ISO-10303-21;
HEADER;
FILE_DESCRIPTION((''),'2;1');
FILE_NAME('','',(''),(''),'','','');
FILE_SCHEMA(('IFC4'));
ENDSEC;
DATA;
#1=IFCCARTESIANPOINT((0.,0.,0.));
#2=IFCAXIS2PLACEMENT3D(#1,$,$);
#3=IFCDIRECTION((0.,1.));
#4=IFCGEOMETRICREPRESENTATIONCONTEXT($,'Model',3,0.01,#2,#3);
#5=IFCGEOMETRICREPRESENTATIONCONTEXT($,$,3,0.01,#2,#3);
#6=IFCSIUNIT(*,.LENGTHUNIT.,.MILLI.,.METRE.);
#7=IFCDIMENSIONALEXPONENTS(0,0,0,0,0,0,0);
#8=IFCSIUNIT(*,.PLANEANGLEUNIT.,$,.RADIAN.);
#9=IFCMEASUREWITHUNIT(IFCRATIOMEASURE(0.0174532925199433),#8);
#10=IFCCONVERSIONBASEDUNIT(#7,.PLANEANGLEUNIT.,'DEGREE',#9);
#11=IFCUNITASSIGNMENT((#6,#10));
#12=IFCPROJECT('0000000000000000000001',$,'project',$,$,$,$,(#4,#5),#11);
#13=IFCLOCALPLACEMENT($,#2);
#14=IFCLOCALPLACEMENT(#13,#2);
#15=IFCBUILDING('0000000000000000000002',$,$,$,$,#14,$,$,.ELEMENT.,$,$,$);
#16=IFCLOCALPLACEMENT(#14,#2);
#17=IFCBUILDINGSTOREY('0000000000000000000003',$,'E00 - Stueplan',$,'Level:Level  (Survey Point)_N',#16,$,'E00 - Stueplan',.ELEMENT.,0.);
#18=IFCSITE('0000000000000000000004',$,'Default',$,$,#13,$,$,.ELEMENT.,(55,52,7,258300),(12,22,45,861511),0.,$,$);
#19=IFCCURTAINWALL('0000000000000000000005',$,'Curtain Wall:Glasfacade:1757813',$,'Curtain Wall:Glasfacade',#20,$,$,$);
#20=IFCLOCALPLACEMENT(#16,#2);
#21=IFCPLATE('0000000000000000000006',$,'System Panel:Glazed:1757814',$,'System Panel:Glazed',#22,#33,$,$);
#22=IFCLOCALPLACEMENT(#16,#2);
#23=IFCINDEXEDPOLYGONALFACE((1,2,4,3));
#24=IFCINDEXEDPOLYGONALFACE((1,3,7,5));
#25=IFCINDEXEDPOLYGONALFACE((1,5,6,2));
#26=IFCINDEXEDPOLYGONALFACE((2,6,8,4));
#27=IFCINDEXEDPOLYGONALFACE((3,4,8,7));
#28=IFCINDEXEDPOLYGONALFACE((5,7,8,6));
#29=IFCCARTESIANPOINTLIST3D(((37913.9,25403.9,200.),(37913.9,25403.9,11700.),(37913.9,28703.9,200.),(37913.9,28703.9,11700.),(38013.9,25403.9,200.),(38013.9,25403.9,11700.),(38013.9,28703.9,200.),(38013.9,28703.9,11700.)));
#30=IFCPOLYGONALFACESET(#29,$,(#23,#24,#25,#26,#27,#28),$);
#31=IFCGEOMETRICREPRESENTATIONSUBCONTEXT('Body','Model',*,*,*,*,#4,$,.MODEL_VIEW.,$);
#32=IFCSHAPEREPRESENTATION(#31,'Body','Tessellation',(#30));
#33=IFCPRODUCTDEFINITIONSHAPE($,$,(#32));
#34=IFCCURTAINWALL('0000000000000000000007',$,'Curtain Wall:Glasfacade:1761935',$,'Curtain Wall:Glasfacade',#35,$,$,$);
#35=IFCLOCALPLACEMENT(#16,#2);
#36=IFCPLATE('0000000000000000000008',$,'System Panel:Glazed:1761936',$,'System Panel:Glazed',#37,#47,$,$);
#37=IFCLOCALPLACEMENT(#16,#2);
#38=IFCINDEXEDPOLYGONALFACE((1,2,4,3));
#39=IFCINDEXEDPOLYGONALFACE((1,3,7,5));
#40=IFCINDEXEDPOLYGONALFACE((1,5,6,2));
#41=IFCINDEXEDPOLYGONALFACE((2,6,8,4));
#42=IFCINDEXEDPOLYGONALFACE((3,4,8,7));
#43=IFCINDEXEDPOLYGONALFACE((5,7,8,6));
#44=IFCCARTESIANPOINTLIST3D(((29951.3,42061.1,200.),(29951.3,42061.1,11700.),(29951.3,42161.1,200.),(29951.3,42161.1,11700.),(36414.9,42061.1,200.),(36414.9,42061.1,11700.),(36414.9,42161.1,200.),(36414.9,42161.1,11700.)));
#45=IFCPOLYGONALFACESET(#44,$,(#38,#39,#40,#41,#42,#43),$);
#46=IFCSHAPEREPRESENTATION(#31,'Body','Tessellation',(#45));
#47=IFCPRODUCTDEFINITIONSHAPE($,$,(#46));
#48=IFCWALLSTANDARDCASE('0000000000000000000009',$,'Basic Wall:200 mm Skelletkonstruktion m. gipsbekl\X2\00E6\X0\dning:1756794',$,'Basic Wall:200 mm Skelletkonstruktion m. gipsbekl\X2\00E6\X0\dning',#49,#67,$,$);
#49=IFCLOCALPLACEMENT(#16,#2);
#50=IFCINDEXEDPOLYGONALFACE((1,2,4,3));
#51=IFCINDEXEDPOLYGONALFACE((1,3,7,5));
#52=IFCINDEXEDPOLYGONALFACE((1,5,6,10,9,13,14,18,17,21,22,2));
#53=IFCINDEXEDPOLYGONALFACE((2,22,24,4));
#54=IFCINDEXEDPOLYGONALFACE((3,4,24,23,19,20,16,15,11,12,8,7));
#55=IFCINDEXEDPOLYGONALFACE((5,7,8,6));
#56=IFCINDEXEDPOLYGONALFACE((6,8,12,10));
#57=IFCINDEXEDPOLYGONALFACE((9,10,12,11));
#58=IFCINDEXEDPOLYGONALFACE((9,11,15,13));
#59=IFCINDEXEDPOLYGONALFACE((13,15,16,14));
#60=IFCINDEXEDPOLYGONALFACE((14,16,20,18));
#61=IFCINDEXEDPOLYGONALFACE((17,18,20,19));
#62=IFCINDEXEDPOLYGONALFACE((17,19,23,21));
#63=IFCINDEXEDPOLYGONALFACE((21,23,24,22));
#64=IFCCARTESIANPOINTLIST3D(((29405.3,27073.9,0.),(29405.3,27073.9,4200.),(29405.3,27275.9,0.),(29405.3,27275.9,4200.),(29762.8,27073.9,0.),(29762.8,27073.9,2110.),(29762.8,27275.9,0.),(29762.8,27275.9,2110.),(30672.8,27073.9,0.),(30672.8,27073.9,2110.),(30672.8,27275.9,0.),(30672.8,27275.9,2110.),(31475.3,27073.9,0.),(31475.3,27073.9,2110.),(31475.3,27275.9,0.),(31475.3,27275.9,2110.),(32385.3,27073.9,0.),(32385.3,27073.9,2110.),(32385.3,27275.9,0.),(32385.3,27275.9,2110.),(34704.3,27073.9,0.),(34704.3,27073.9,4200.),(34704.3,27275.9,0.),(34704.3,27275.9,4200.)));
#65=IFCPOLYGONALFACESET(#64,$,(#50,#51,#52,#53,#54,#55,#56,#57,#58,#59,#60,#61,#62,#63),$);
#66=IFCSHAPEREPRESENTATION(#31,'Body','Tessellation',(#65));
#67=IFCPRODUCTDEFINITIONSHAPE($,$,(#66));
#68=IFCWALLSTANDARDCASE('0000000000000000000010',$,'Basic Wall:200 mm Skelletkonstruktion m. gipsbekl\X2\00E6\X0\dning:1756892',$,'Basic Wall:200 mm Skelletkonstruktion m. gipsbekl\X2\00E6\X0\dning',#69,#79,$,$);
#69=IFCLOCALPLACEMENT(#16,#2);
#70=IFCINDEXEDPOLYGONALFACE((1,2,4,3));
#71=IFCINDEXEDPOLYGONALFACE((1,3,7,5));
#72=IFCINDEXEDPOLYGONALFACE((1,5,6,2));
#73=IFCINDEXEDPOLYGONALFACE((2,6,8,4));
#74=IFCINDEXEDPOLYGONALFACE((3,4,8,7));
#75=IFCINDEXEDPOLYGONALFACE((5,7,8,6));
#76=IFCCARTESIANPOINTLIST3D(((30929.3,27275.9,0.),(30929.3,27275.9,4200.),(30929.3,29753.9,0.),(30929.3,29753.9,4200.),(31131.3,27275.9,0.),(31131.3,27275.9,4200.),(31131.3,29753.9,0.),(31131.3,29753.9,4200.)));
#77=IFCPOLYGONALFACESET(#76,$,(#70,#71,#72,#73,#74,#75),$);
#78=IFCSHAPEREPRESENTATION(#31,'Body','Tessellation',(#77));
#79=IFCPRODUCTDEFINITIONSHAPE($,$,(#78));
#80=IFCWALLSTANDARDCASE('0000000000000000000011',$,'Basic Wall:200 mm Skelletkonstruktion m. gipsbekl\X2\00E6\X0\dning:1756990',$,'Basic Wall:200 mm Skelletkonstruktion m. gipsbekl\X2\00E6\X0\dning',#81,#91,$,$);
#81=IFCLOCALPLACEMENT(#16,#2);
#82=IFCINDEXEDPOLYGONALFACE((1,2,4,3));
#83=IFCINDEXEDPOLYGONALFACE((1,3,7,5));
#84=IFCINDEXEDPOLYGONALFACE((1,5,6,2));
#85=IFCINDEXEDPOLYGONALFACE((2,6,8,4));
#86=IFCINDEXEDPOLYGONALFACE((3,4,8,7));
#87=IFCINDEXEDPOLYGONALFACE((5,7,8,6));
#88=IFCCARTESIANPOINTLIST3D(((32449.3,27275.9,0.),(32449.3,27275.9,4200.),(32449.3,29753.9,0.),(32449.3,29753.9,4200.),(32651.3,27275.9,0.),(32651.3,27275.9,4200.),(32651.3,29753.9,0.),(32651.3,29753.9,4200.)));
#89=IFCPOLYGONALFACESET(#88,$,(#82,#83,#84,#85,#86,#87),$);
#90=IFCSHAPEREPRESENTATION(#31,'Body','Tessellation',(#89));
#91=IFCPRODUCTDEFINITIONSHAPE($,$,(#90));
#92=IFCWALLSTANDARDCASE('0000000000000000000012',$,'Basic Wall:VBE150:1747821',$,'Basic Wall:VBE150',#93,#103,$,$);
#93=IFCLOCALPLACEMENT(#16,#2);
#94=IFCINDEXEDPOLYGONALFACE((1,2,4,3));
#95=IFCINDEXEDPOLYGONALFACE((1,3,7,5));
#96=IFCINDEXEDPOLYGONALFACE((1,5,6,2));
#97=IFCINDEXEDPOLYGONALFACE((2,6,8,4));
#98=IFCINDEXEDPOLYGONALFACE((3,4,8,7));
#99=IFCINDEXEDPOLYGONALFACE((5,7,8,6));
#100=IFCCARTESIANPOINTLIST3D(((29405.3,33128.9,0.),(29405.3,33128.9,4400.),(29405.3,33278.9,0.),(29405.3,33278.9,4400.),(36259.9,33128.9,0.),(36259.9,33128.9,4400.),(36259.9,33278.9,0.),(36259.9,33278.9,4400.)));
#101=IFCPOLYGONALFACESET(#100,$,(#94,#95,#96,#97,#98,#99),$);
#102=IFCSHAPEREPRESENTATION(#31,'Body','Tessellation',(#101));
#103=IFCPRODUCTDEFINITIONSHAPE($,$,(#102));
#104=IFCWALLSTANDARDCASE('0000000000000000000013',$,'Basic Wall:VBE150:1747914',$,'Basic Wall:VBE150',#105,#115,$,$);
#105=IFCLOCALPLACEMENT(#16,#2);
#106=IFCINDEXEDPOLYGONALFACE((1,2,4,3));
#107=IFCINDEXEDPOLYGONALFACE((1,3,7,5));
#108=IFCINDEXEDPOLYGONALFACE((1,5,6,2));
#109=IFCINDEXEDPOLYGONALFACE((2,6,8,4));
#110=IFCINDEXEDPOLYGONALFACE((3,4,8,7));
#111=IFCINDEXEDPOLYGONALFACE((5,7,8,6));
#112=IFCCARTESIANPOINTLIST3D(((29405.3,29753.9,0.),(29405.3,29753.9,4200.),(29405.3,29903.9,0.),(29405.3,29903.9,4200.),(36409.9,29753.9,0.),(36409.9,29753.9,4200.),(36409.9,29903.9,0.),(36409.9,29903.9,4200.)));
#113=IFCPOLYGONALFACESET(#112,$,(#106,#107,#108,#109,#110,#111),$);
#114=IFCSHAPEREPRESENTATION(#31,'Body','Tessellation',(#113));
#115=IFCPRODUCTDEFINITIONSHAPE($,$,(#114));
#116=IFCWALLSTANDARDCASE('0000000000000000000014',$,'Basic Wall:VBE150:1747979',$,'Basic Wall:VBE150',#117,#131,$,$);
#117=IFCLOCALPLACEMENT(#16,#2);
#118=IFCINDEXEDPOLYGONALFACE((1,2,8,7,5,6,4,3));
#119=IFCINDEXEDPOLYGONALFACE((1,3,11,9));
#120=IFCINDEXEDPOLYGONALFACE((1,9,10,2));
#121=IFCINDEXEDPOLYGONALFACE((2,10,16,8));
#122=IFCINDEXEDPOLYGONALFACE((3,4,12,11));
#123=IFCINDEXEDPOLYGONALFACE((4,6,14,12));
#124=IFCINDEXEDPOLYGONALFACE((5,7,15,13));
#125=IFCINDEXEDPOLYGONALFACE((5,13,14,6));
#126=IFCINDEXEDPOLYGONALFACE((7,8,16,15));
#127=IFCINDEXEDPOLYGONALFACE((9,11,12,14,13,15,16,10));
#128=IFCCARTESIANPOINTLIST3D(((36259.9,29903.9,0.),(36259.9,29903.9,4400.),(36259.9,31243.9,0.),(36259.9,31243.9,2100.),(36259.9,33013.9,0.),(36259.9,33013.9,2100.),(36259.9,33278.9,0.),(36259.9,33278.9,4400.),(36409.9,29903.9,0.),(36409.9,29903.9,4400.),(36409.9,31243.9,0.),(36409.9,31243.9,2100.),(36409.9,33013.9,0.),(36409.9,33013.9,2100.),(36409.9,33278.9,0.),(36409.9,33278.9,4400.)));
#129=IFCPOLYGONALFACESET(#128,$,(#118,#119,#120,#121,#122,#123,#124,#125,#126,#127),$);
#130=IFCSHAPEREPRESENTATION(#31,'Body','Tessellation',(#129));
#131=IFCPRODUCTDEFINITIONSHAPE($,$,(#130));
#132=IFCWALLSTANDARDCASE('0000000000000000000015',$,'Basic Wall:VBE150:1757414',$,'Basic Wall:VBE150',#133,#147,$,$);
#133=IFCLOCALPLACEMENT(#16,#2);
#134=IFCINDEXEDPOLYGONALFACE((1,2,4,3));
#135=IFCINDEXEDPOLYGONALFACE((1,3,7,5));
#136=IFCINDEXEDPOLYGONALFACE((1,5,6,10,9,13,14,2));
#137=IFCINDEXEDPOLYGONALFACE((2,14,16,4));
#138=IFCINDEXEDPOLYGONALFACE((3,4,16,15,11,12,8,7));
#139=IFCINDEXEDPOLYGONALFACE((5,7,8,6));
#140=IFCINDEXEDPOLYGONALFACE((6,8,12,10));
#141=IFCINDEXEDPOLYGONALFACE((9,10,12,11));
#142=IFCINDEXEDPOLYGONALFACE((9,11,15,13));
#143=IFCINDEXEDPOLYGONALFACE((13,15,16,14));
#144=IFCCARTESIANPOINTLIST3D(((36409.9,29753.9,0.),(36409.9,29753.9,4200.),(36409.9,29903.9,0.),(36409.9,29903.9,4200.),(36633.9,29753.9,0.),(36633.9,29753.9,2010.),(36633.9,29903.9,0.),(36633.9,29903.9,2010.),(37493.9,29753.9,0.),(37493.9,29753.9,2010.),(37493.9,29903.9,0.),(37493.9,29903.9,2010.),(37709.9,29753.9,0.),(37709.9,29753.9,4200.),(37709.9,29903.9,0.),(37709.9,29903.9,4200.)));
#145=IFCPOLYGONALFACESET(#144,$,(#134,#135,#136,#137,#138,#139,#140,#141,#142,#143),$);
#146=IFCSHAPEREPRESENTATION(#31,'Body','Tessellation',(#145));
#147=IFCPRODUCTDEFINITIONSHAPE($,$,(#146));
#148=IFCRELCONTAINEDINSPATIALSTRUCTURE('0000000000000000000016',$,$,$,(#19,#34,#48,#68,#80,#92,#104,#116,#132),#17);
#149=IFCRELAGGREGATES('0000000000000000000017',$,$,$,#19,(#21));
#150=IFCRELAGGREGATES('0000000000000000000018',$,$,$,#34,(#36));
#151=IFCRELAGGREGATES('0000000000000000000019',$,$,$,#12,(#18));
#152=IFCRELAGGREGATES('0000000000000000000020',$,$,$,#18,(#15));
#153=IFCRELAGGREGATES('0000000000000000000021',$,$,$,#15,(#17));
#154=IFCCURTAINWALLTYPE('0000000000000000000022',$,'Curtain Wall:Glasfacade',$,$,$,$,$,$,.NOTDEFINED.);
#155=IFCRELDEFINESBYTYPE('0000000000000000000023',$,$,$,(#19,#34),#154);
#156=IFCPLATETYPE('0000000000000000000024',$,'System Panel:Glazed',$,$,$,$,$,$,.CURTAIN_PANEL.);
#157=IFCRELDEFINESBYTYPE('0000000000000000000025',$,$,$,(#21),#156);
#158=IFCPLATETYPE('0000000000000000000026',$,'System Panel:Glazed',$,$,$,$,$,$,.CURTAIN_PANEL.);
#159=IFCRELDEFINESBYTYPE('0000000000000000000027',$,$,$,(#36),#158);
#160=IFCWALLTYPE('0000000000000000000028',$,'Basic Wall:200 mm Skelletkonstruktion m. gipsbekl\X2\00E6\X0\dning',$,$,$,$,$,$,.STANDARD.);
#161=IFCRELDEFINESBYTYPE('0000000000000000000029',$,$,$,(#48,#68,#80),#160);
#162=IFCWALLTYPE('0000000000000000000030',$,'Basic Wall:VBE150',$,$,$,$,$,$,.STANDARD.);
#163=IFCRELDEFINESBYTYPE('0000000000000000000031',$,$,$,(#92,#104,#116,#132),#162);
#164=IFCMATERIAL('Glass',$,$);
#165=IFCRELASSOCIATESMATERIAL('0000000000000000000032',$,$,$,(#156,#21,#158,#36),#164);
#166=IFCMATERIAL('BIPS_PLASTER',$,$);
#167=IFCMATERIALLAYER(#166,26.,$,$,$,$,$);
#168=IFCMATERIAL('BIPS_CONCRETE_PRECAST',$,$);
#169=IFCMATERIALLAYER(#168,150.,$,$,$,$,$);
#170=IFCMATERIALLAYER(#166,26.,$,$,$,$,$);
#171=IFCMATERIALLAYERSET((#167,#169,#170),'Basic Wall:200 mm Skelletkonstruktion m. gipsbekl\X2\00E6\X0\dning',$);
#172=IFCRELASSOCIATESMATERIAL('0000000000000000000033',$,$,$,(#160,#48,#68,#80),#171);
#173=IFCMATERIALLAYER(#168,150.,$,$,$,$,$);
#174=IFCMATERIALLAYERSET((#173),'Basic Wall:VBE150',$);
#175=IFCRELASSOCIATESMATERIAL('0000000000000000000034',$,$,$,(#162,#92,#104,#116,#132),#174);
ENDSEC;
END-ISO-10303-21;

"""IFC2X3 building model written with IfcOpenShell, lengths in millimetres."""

from ifc_helpers import new_model, entity, si_unit, converted_unit, direction, frame, frame_2d, origin, origin_2d_with_axis, place, context, subcontext, project, spatial, rectangle, extrude, source, transform, mapped, material, layer, layer_set, layer_usage, type_object, type_shapes, element, aggregate, save


model = new_model("IFC2X3")

# Units and contexts
model_context = context("Model", 3, precision=0.01, world=origin(), true_north=direction((0.0, 1.0)))
context_of_model = context(None, 3, precision=0.01, world=origin(), true_north=direction((0.0, 1.0)))
body_context = subcontext(model_context, "Body", "Model", "MODEL_VIEW")
ifc_project = project(units=[si_unit("LENGTHUNIT", "METRE", prefix="MILLI"), converted_unit("PLANEANGLEUNIT", "DEGREE", entity("IfcRatioMeasure", 0.0174532925199433), si_unit("PLANEANGLEUNIT", "RADIAN"), dimensions=[0, 0, 0, 0, 0, 0, 0])], contexts=[model_context, context_of_model])

# Site, building, storey
site_placement = place(None, origin())
site = spatial("IfcSite", under=ifc_project, at=site_placement, Name="Default", CompositionType="ELEMENT", RefLatitude=(55, 52, 7, 258300), RefLongitude=(12, 22, 45, 861511), RefElevation=0.0)
building_placement = place(site_placement, origin())
building = spatial("IfcBuilding", under=site, at=building_placement, CompositionType="ELEMENT")
storey_placement = place(building_placement, origin())
storey = spatial("IfcBuildingStorey", under=building, at=storey_placement, Name="E00 - Stueplan", ObjectType="Level:Level  (Survey Point)_N", LongName="E00 - Stueplan", CompositionType="ELEMENT", Elevation=0.0)

# Curtain walls, plates
curtain_wall_type = type_object("IfcCurtainWallType", Name="Curtain Wall:Glasfacade", PredefinedType="NOTDEFINED")
curtain_wall_1_placement = place(storey_placement, origin())
curtain_wall_1 = element("IfcCurtainWall", 1, at=curtain_wall_1_placement, inside=storey, type_object=curtain_wall_type, Name="Curtain Wall:Glasfacade:1757813", ObjectType="Curtain Wall:Glasfacade")
ifc_material_1 = material(Name="Glass")
plate_type_1 = type_object("IfcPlateType", Name="System Panel:Glazed", PredefinedType="CURTAIN_PANEL", material=ifc_material_1)
shared_shape_1 = source(origin(), body_context, "Body", "SweptSolid", [
    extrude(rectangle(XDim=100.0, YDim=3300.0, at=origin_2d_with_axis()), frame((0.0, 0.0, 0.0), z_axis=(0.0, 0.0, 1.0), x_axis=(0.0, 1.0, 0.0)), (0.0, 0.0, 1.0), 11500.0),
])
type_shapes(plate_type_1, [shared_shape_1])
plate_1_placement = place(curtain_wall_1_placement, frame((37963.9, 27053.9, 200.0), z_axis=(0.0, 0.0, 1.0), x_axis=(0.0, -1.0, 0.0)))
plate_1 = element("IfcPlate", 2, at=plate_1_placement, type_object=plate_type_1, material=ifc_material_1, Name="System Panel:Glazed:1757814", ObjectType="System Panel:Glazed", context=body_context, shape_type="MappedRepresentation", body=[
    mapped(shared_shape_1, transform((0.0, 0.0, 0.0), scale=1.0)),
])
aggregate(curtain_wall_1, [plate_1])
curtain_wall_2_placement = place(storey_placement, origin())
curtain_wall_2 = element("IfcCurtainWall", 3, at=curtain_wall_2_placement, inside=storey, type_object=curtain_wall_type, Name="Curtain Wall:Glasfacade:1761935", ObjectType="Curtain Wall:Glasfacade")
plate_type_2 = type_object("IfcPlateType", Name="System Panel:Glazed", PredefinedType="CURTAIN_PANEL", material=ifc_material_1)
shared_shape_2 = source(origin(), body_context, "Body", "SweptSolid", [
    extrude(rectangle(XDim=100.0, YDim=6463.6, at=origin_2d_with_axis()), frame((0.0, 0.0, 0.0), z_axis=(0.0, 0.0, 1.0), x_axis=(0.0, 1.0, 0.0)), (0.0, 0.0, 1.0), 11500.0),
])
type_shapes(plate_type_2, [shared_shape_2])
plate_2_placement = place(curtain_wall_2_placement, frame((33183.1, 42111.1, 200.0)))
plate_2 = element("IfcPlate", 4, at=plate_2_placement, type_object=plate_type_2, material=ifc_material_1, Name="System Panel:Glazed:1761936", ObjectType="System Panel:Glazed", context=body_context, shape_type="MappedRepresentation", body=[
    mapped(shared_shape_2, transform((0.0, 0.0, 0.0), scale=1.0)),
])
aggregate(curtain_wall_2, [plate_2])

# Wall, openings
ifc_material_2 = material(Name="BIPS_CONCRETE_PRECAST")
ifc_material_3 = material(Name="BIPS_PLASTER")
ifc_layer_1 = layer(ifc_material_3, 26.0)
ifc_layer_2 = layer(ifc_material_2, 150.0)
ifc_layer_3 = layer(ifc_material_3, 26.0)
ifc_layer_set_1 = layer_set([ifc_layer_1, ifc_layer_2, ifc_layer_3], Name="Basic Wall:200 mm Skelletkonstruktion m. gipsbeklædning")
ifc_layer_usage_1 = layer_usage(ifc_layer_set_1, "AXIS2", "NEGATIVE", 101.0)
wall_type_1 = type_object("IfcWallType", Name="Basic Wall:200 mm Skelletkonstruktion m. gipsbeklædning", PredefinedType="STANDARD", material=ifc_layer_set_1)
wall_1_placement = place(storey_placement, frame((29405.3, 27174.9, 0.0)))
wall_1 = element("IfcWallStandardCase", 5, at=wall_1_placement, inside=storey, type_object=wall_type_1, material=ifc_layer_usage_1, Name="Basic Wall:200 mm Skelletkonstruktion m. gipsbeklædning:1756794", ObjectType="Basic Wall:200 mm Skelletkonstruktion m. gipsbeklædning", context=body_context, shape_type="SweptSolid", body=[
    extrude(rectangle(XDim=5299.0, YDim=202.0, at=frame_2d((2649.5, 0.0), x_axis=(-1.0, 0.0))), origin(), (0.0, 0.0, 1.0), 4200.0),
])
opening_1_placement = place(wall_1_placement, frame((357.5, -101.0, 0.0)))
element("IfcOpeningElement", 6, at=opening_1_placement, cuts=wall_1, ObjectType="Opening", context=body_context, shape_type="SweptSolid", body=[
    extrude(rectangle(XDim=2110.0, YDim=910.0, at=frame_2d((1055.0, 455.0), x_axis=(1.0, 0.0))), frame((0.0, 0.0, 0.0), z_axis=(0.0, 1.0, 0.0), x_axis=(0.0, 0.0, 1.0)), (0.0, 0.0, 1.0), 202.0),
])
opening_2_placement = place(wall_1_placement, frame((2070.0, -101.0, 0.0)))
element("IfcOpeningElement", 7, at=opening_2_placement, cuts=wall_1, ObjectType="Opening", context=body_context, shape_type="SweptSolid", body=[
    extrude(rectangle(XDim=2110.0, YDim=910.0, at=frame_2d((1055.0, 455.0), x_axis=(1.0, 0.0))), frame((0.0, 0.0, 0.0), z_axis=(0.0, 1.0, 0.0), x_axis=(0.0, 0.0, 1.0)), (0.0, 0.0, 1.0), 202.0),
])

# Walls
ifc_layer_usage_2 = layer_usage(ifc_layer_set_1, "AXIS2", "NEGATIVE", 101.0)
wall_2_placement = place(storey_placement, frame((31030.3, 29753.9, 0.0), z_axis=(0.0, 0.0, 1.0), x_axis=(0.0, -1.0, 0.0)))
element("IfcWallStandardCase", 8, at=wall_2_placement, inside=storey, type_object=wall_type_1, material=ifc_layer_usage_2, Name="Basic Wall:200 mm Skelletkonstruktion m. gipsbeklædning:1756892", ObjectType="Basic Wall:200 mm Skelletkonstruktion m. gipsbeklædning", context=body_context, shape_type="SweptSolid", body=[
    extrude(rectangle(XDim=2478.0, YDim=202.0, at=frame_2d((1239.0, 0.0), x_axis=(-1.0, 0.0))), origin(), (0.0, 0.0, 1.0), 4200.0),
])
ifc_layer_usage_3 = layer_usage(ifc_layer_set_1, "AXIS2", "NEGATIVE", 101.0)
wall_3_placement = place(storey_placement, frame((32550.3, 29753.9, 0.0), z_axis=(0.0, 0.0, 1.0), x_axis=(0.0, -1.0, 0.0)))
element("IfcWallStandardCase", 9, at=wall_3_placement, inside=storey, type_object=wall_type_1, material=ifc_layer_usage_3, Name="Basic Wall:200 mm Skelletkonstruktion m. gipsbeklædning:1756990", ObjectType="Basic Wall:200 mm Skelletkonstruktion m. gipsbeklædning", context=body_context, shape_type="SweptSolid", body=[
    extrude(rectangle(XDim=2478.0, YDim=202.0, at=frame_2d((1239.0, 0.0), x_axis=(-1.0, 0.0))), origin(), (0.0, 0.0, 1.0), 4200.0),
])
ifc_layer_4 = layer(ifc_material_2, 150.0)
ifc_layer_set_2 = layer_set([ifc_layer_4], Name="Basic Wall:VBE150")
ifc_layer_usage_4 = layer_usage(ifc_layer_set_2, "AXIS2", "NEGATIVE", 75.0)
wall_type_2 = type_object("IfcWallType", Name="Basic Wall:VBE150", PredefinedType="STANDARD", material=ifc_layer_set_2)
wall_4_placement = place(storey_placement, frame((29405.3, 33203.9, 0.0)))
element("IfcWallStandardCase", 10, at=wall_4_placement, inside=storey, type_object=wall_type_2, material=ifc_layer_usage_4, Name="Basic Wall:VBE150:1747821", ObjectType="Basic Wall:VBE150", context=body_context, shape_type="SweptSolid", body=[
    extrude(rectangle(XDim=6854.6, YDim=150.0, at=frame_2d((3427.3, 0.0), x_axis=(-1.0, 0.0))), origin(), (0.0, 0.0, 1.0), 4400.0),
])
ifc_layer_usage_5 = layer_usage(ifc_layer_set_2, "AXIS2", "NEGATIVE", 75.0)
wall_5_placement = place(storey_placement, frame((29405.3, 29828.9, 0.0)))
element("IfcWallStandardCase", 11, at=wall_5_placement, inside=storey, type_object=wall_type_2, material=ifc_layer_usage_5, Name="Basic Wall:VBE150:1747914", ObjectType="Basic Wall:VBE150", context=body_context, shape_type="SweptSolid", body=[
    extrude(rectangle(XDim=7004.6, YDim=150.0, at=frame_2d((3502.3, 0.0), x_axis=(-1.0, 0.0))), origin(), (0.0, 0.0, 1.0), 4200.0),
])

# Walls, openings
ifc_layer_usage_6 = layer_usage(ifc_layer_set_2, "AXIS2", "NEGATIVE", 75.0)
wall_6_placement = place(storey_placement, frame((36334.9, 29903.9, 0.0), z_axis=(0.0, 0.0, 1.0), x_axis=(0.0, 1.0, 0.0)))
wall_6 = element("IfcWallStandardCase", 12, at=wall_6_placement, inside=storey, type_object=wall_type_2, material=ifc_layer_usage_6, Name="Basic Wall:VBE150:1747979", ObjectType="Basic Wall:VBE150", context=body_context, shape_type="SweptSolid", body=[
    extrude(rectangle(XDim=3375.0, YDim=150.0, at=frame_2d((1687.5, 0.0), x_axis=(-1.0, 0.0))), origin(), (0.0, 0.0, 1.0), 4400.0),
])
opening_3_placement = place(wall_6_placement, frame((1340.0, -75.0, 0.0)))
element("IfcOpeningElement", 13, at=opening_3_placement, cuts=wall_6, ObjectType="Opening", context=body_context, shape_type="SweptSolid", body=[
    extrude(rectangle(XDim=2100.0, YDim=1770.0, at=frame_2d((1050.0, 885.0), x_axis=(1.0, 0.0))), frame((0.0, 0.0, 0.0), z_axis=(0.0, 1.0, 0.0), x_axis=(0.0, 0.0, 1.0)), (0.0, 0.0, 1.0), 150.0),
])
ifc_layer_usage_7 = layer_usage(ifc_layer_set_2, "AXIS2", "NEGATIVE", 75.0)
wall_7_placement = place(storey_placement, frame((36409.9, 29828.9, 0.0)))
wall_7 = element("IfcWallStandardCase", 14, at=wall_7_placement, inside=storey, type_object=wall_type_2, material=ifc_layer_usage_7, Name="Basic Wall:VBE150:1757414", ObjectType="Basic Wall:VBE150", context=body_context, shape_type="SweptSolid", body=[
    extrude(rectangle(XDim=1300.0, YDim=150.0, at=frame_2d((650.0, 0.0), x_axis=(-1.0, 0.0))), origin(), (0.0, 0.0, 1.0), 4200.0),
])
opening_4_placement = place(wall_7_placement, frame((224.0, -75.0, 0.0)))
element("IfcOpeningElement", 15, at=opening_4_placement, cuts=wall_7, ObjectType="Opening", context=body_context, shape_type="SweptSolid", body=[
    extrude(rectangle(XDim=2010.0, YDim=860.0, at=frame_2d((1005.0, 430.0), x_axis=(1.0, 0.0))), frame((0.0, 0.0, 0.0), z_axis=(0.0, 1.0, 0.0), x_axis=(0.0, 0.0, 1.0)), (0.0, 0.0, 1.0), 150.0),
])

save(model, "model.ifc")
